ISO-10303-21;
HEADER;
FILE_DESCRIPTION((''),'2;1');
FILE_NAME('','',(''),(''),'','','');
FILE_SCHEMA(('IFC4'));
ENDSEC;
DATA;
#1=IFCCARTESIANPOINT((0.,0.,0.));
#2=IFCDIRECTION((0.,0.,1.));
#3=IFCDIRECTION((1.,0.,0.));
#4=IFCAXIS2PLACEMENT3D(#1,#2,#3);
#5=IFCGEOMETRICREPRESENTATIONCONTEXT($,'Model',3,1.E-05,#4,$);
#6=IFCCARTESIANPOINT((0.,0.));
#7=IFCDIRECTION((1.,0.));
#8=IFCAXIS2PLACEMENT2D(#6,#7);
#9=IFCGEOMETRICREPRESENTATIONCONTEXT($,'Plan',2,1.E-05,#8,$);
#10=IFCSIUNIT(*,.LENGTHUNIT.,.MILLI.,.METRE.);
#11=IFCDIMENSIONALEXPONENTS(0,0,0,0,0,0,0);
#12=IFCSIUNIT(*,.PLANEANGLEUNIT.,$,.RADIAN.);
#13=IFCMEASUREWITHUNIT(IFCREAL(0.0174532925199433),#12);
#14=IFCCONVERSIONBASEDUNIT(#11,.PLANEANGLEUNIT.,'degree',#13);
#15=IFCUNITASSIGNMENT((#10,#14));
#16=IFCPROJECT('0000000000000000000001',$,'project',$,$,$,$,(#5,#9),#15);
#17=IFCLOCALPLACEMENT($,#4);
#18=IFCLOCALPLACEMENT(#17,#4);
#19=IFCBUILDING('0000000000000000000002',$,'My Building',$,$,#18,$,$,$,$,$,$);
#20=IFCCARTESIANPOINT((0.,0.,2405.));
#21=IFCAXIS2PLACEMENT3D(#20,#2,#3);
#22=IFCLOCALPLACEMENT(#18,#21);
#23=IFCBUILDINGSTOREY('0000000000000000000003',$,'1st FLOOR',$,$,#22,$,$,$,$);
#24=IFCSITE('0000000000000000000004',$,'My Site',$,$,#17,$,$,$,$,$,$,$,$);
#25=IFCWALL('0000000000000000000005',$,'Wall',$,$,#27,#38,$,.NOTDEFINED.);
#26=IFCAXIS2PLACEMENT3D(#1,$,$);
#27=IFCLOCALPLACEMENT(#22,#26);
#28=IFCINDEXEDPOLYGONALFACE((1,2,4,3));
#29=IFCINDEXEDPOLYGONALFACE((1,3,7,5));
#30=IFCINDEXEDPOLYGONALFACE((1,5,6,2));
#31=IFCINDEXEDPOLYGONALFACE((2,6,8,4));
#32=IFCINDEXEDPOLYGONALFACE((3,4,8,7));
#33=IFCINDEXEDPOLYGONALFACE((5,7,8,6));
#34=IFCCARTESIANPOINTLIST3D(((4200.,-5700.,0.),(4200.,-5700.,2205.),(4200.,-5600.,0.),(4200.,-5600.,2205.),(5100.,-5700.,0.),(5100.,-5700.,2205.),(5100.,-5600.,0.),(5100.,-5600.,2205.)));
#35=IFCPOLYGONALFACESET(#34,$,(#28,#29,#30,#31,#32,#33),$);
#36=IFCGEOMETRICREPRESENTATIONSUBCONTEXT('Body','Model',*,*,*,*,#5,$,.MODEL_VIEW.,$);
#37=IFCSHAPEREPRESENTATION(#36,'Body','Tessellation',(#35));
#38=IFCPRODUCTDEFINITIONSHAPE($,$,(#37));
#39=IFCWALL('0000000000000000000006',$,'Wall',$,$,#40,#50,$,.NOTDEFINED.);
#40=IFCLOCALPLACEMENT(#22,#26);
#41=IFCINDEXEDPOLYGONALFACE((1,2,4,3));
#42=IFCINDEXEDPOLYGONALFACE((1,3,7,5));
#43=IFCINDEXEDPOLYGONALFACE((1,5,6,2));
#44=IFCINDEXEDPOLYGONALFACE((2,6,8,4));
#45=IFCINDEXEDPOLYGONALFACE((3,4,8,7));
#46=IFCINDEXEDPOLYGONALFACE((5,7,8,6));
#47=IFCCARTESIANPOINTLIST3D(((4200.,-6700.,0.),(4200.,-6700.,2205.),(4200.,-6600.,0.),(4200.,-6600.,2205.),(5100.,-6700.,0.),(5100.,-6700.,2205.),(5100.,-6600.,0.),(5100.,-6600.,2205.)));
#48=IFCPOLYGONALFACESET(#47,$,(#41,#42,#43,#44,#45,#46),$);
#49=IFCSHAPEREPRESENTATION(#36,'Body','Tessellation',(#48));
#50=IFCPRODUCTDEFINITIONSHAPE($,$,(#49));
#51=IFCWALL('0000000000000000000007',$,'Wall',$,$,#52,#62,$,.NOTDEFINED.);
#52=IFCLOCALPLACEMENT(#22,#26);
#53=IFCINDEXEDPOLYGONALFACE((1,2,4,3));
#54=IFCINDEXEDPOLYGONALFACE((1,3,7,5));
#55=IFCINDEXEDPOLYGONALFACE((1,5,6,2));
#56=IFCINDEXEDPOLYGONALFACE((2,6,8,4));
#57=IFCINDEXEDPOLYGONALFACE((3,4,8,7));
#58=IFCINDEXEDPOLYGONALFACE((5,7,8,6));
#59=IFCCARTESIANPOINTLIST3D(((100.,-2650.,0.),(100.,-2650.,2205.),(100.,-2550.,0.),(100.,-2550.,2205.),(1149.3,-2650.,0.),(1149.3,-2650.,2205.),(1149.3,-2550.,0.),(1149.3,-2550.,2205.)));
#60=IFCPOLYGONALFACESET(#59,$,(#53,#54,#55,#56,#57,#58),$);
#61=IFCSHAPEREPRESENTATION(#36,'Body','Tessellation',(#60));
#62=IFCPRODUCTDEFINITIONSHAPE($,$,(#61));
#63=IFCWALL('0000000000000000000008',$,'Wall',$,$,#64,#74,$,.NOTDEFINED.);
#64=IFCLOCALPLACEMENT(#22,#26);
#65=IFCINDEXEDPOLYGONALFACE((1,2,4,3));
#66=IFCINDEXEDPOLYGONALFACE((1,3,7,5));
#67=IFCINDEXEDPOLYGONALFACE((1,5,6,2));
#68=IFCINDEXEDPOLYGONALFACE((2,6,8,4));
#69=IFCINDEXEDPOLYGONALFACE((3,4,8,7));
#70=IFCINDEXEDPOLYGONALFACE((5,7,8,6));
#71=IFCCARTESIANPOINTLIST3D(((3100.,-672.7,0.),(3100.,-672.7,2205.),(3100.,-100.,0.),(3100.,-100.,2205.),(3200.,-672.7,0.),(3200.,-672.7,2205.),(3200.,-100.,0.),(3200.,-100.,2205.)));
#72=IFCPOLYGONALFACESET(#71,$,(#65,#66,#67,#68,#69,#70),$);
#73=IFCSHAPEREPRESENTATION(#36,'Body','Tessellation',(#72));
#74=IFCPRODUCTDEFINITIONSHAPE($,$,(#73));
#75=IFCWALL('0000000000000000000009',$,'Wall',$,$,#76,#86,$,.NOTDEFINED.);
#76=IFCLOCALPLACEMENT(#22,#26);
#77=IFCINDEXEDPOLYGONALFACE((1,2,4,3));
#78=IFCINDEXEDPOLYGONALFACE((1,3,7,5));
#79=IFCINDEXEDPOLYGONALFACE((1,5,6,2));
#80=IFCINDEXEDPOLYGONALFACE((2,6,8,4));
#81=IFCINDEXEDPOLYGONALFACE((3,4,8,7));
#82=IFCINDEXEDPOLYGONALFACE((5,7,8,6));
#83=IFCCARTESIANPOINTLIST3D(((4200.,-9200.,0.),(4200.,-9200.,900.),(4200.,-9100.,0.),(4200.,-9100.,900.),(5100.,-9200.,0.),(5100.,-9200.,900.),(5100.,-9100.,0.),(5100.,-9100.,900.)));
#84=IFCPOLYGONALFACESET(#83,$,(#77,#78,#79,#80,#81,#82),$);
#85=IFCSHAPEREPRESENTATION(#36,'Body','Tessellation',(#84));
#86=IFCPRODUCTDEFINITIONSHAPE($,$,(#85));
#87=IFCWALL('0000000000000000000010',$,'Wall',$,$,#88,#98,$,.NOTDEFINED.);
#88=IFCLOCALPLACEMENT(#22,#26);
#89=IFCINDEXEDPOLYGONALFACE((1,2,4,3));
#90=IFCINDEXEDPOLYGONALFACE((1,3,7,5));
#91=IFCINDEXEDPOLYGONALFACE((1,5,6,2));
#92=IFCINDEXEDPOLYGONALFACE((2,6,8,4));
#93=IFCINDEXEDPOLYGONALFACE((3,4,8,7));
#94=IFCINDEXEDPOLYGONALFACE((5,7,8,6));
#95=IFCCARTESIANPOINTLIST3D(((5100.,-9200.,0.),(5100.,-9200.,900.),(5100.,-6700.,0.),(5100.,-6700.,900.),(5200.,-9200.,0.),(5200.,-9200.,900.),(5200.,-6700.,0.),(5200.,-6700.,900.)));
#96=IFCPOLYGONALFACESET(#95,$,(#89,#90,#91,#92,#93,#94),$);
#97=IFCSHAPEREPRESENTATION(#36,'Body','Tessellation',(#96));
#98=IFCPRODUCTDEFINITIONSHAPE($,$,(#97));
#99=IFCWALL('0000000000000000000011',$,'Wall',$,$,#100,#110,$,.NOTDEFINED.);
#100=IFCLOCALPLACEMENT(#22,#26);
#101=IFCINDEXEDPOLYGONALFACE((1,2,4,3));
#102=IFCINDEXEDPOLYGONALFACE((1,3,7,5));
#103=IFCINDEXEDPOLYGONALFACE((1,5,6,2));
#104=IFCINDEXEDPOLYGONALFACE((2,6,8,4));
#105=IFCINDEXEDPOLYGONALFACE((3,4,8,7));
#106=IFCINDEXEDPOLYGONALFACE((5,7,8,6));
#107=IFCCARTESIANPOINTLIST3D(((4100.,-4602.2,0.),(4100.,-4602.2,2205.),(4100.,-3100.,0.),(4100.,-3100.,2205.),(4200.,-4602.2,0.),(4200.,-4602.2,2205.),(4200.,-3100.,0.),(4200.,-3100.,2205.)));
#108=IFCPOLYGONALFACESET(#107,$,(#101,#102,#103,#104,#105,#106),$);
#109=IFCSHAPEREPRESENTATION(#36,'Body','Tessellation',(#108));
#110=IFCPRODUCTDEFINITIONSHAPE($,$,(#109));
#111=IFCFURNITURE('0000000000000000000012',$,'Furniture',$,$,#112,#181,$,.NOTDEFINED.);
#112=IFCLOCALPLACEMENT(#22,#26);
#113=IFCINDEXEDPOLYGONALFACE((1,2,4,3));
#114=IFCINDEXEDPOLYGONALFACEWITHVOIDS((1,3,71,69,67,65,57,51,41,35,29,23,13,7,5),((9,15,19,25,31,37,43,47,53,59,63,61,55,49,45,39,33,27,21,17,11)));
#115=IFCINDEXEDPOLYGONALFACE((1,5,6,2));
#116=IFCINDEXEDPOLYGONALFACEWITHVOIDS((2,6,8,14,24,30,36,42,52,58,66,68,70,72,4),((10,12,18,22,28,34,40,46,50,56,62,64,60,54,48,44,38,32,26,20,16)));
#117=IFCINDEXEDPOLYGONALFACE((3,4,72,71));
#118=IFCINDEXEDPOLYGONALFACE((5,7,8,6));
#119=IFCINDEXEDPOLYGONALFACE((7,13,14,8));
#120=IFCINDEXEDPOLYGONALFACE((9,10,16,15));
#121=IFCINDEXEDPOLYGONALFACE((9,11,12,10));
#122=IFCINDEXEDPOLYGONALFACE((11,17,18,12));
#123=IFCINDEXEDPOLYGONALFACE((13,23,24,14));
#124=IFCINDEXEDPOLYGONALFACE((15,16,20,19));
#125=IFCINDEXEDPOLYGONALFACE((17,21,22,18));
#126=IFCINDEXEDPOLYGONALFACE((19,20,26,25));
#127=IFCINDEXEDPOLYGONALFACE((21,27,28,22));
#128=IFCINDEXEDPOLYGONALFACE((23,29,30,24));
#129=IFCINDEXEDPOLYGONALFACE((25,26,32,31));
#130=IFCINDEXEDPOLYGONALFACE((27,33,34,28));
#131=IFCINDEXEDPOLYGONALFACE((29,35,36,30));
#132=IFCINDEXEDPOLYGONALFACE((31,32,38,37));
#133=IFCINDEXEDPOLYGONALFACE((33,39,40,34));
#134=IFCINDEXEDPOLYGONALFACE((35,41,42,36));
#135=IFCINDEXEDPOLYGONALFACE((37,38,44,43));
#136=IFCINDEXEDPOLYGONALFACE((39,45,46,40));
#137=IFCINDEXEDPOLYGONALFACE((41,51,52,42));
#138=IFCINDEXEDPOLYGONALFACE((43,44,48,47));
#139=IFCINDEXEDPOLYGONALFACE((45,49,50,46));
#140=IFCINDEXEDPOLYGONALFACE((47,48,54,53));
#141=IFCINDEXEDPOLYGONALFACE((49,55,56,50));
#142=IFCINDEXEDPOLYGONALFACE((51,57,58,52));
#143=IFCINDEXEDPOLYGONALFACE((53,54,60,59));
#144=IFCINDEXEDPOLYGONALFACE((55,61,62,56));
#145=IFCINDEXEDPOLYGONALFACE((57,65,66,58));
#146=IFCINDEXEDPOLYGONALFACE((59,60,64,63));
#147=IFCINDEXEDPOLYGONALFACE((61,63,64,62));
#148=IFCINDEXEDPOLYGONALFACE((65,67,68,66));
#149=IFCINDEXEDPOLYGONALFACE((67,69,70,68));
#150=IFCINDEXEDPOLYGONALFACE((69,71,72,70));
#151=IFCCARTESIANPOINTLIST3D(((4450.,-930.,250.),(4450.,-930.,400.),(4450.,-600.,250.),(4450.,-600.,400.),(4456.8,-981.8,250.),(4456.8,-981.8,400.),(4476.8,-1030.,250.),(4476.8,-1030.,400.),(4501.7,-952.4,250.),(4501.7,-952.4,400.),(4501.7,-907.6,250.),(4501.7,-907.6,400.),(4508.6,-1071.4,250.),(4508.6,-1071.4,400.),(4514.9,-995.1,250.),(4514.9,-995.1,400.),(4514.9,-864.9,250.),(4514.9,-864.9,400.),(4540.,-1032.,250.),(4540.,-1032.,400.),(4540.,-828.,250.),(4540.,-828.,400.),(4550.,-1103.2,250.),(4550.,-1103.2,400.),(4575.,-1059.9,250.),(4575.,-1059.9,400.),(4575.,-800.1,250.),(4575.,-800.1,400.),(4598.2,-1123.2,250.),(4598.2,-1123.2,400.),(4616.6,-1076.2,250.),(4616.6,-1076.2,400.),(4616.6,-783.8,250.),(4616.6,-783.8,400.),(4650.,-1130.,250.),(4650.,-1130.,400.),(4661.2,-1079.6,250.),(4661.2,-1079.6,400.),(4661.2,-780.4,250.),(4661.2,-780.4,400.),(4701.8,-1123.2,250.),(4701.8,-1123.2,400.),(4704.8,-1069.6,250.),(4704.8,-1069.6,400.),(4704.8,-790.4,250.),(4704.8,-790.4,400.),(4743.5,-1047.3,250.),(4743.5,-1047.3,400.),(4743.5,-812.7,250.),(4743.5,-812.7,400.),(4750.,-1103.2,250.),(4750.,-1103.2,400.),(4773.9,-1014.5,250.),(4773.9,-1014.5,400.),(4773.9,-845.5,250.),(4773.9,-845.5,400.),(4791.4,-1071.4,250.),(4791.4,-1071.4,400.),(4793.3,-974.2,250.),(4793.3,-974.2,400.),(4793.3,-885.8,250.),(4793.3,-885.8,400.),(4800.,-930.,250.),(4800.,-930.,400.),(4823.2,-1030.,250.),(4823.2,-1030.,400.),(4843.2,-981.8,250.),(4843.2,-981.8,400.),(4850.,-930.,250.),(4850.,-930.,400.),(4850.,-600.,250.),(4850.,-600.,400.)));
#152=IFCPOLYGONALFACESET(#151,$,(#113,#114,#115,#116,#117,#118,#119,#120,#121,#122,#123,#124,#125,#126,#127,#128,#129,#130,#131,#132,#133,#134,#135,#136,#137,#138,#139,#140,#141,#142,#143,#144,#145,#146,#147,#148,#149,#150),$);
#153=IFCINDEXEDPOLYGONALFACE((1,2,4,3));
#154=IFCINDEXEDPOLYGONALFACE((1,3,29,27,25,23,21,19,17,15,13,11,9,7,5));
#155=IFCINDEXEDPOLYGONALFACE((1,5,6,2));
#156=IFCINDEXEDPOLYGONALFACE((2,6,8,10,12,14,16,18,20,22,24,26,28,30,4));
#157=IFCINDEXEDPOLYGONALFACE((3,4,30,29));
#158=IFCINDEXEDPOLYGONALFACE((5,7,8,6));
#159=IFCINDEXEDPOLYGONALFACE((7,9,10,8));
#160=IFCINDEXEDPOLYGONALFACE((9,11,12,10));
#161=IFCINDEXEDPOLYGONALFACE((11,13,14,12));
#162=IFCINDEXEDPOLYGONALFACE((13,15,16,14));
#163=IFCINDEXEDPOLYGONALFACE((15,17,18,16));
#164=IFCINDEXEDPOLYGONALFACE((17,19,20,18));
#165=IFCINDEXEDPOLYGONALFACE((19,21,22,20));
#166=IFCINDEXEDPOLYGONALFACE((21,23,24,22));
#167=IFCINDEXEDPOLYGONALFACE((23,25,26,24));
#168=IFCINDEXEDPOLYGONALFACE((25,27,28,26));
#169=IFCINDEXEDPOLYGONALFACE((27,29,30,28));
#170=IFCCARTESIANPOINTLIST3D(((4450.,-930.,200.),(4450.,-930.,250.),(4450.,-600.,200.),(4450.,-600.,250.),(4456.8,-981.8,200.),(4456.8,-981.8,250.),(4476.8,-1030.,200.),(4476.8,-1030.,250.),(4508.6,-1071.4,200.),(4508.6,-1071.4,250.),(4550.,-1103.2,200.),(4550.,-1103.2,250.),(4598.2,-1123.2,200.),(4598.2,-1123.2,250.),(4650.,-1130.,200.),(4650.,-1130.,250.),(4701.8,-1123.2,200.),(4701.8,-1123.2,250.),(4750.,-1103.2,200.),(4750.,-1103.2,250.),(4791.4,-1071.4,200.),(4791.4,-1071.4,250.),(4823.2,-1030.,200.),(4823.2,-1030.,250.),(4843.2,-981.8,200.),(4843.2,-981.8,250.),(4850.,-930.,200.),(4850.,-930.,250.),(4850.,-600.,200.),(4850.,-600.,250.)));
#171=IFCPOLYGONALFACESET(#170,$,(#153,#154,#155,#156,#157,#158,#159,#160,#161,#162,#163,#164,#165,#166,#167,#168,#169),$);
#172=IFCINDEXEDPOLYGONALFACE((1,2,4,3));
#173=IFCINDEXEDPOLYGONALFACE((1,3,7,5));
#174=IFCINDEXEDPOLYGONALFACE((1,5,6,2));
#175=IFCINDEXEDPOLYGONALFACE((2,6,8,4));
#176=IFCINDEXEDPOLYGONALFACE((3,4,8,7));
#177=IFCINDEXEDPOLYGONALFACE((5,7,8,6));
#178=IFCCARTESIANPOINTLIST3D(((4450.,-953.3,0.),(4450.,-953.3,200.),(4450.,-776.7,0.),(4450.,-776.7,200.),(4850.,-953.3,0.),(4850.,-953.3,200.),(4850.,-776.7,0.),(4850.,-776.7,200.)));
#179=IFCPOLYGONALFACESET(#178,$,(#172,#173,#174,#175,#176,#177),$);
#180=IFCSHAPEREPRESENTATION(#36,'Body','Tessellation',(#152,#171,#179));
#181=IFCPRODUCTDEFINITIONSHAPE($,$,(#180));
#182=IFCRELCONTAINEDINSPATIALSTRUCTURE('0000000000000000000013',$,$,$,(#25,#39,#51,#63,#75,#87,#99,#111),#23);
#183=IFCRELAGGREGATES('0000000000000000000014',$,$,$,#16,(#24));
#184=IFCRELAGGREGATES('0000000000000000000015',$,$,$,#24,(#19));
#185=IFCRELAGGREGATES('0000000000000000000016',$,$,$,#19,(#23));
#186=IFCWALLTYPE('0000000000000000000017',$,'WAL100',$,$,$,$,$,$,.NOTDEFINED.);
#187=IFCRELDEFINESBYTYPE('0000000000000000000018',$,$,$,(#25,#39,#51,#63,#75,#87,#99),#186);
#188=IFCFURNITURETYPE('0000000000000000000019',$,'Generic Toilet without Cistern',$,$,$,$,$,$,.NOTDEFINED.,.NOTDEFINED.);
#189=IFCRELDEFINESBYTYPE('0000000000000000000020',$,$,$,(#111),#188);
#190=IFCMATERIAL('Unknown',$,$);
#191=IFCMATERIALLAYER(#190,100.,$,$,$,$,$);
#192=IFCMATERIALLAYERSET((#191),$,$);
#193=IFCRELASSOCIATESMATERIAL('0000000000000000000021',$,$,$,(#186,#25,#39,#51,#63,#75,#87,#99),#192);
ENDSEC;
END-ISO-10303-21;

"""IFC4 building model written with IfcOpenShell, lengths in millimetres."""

from ifc_helpers import new_model, entity, si_unit, converted_unit, frame, frame_2d, origin_with_axes, origin_2d_with_axis, place, context, subcontext, project, spatial, line, arc, indexed_curve, circle_curve, outline, extrude, source, transform, mapped, material, layer, layer_set, layer_usage, type_object, type_shapes, element, save


model = new_model("IFC4")

# Units and contexts
model_context = context("Model", 3, precision=1e-05, world=origin_with_axes())
plan_context = context("Plan", 2, precision=1e-05, world=origin_2d_with_axis())
body_context = subcontext(model_context, "Body", "Model", "MODEL_VIEW")
ifc_project = project(units=[si_unit("LENGTHUNIT", "METRE", prefix="MILLI"), converted_unit("PLANEANGLEUNIT", "degree", entity("IfcReal", 0.0174532925199433), si_unit("PLANEANGLEUNIT", "RADIAN"), dimensions=[0, 0, 0, 0, 0, 0, 0])], contexts=[model_context, plan_context])

# Site, building, storey
site_placement = place(None, origin_with_axes())
site = spatial("IfcSite", under=ifc_project, at=site_placement, Name="My Site")
building_placement = place(site_placement, origin_with_axes())
building = spatial("IfcBuilding", under=site, at=building_placement, Name="My Building")
storey_placement = place(building_placement, frame((0.0, 0.0, 2405.0), z_axis=(0.0, 0.0, 1.0), x_axis=(1.0, 0.0, 0.0)))
storey = spatial("IfcBuildingStorey", under=building, at=storey_placement, Name="1st FLOOR")

# Shared definitions
ifc_material = material(Name="Unknown")

# Walls
ifc_layer_1 = layer(ifc_material, 100.0)
ifc_layer_set_1 = layer_set([ifc_layer_1])
wall_type = type_object("IfcWallType", Name="WAL100", PredefinedType="NOTDEFINED", material=ifc_layer_set_1)
ifc_layer_usage_1 = layer_usage(ifc_layer_set_1, "AXIS2", "POSITIVE", 0.0)
wall_1_placement = place(storey_placement, frame((5100.0, -5600.0, 0.0), z_axis=(0.0, 0.0, 1.0), x_axis=(-1.0, 0.0, 0.0)))
element("IfcWall", 1, at=wall_1_placement, inside=storey, type_object=wall_type, material=ifc_layer_usage_1, Name="Wall", PredefinedType="NOTDEFINED", context=body_context, shape_type="SweptSolid", body=[
    extrude(outline(indexed_curve([(0.0, 0.0), (0.0, 100.0), (900.0, 100.0), (900.0, 0.0), (0.0, 0.0)], self_intersect=False)), origin_with_axes(), (0.0, 0.0, 1.0), 2205.0),
])
ifc_layer_usage_2 = layer_usage(ifc_layer_set_1, "AXIS2", "POSITIVE", 0.0)
wall_2_placement = place(storey_placement, frame((5100.0, -6600.0, 0.0), z_axis=(0.0, 0.0, 1.0), x_axis=(-1.0, 0.0, 0.0)))
element("IfcWall", 2, at=wall_2_placement, inside=storey, type_object=wall_type, material=ifc_layer_usage_2, Name="Wall", PredefinedType="NOTDEFINED", context=body_context, shape_type="SweptSolid", body=[
    extrude(outline(indexed_curve([(0.0, 0.0), (0.0, 100.0), (900.0, 100.0), (900.0, 0.0), (0.0, 0.0)], self_intersect=False)), origin_with_axes(), (0.0, 0.0, 1.0), 2205.0),
])
ifc_layer_usage_3 = layer_usage(ifc_layer_set_1, "AXIS2", "POSITIVE", 0.0)
wall_3_placement = place(storey_placement, frame((1149.3, -2550.0, 0.0), z_axis=(0.0, 0.0, 1.0), x_axis=(-1.0, 0.000001, 0.0)))
element("IfcWall", 3, at=wall_3_placement, inside=storey, type_object=wall_type, material=ifc_layer_usage_3, Name="Wall", PredefinedType="NOTDEFINED", context=body_context, shape_type="SweptSolid", body=[
    extrude(outline(indexed_curve([(0.0, 0.0), (0.0, 100.0), (1049.3, 100.0), (1049.3, 0.0), (0.0, 0.0)], self_intersect=False)), origin_with_axes(), (0.0, 0.0, 1.0), 2205.0),
])
ifc_layer_usage_4 = layer_usage(ifc_layer_set_1, "AXIS2", "POSITIVE", 0.0)
wall_4_placement = place(storey_placement, frame((3200.0, -672.7, 0.0), z_axis=(0.0, 0.0, 1.0), x_axis=(0.000001, 1.0, 0.0)))
element("IfcWall", 4, at=wall_4_placement, inside=storey, type_object=wall_type, material=ifc_layer_usage_4, Name="Wall", PredefinedType="NOTDEFINED", context=body_context, shape_type="SweptSolid", body=[
    extrude(outline(indexed_curve([(0.0, 0.0), (0.0, 100.0), (572.7, 100.0), (572.7, 0.0), (0.0, 0.0)], self_intersect=False)), origin_with_axes(), (0.0, 0.0, 1.0), 2205.0),
])
ifc_layer_usage_5 = layer_usage(ifc_layer_set_1, "AXIS2", "POSITIVE", 0.0)
wall_5_placement = place(storey_placement, frame((4200.0, -9200.0, 0.0), z_axis=(0.0, 0.0, 1.0), x_axis=(1.0, -0.000001, 0.0)))
element("IfcWall", 5, at=wall_5_placement, inside=storey, type_object=wall_type, material=ifc_layer_usage_5, Name="Wall", PredefinedType="NOTDEFINED", context=body_context, shape_type="SweptSolid", body=[
    extrude(outline(indexed_curve([(0.0, 0.0), (0.0, 100.0), (900.0, 100.0), (900.0, 0.0), (0.0, 0.0)], self_intersect=False)), origin_with_axes(), (0.0, 0.0, 1.0), 900.0),
])
ifc_layer_usage_6 = layer_usage(ifc_layer_set_1, "AXIS2", "POSITIVE", 0.0)
wall_6_placement = place(storey_placement, frame((5100.0, -6700.0, 0.0), z_axis=(0.0, 0.0, 1.0), x_axis=(-0.000001, -1.0, 0.0)))
element("IfcWall", 6, at=wall_6_placement, inside=storey, type_object=wall_type, material=ifc_layer_usage_6, Name="Wall", PredefinedType="NOTDEFINED", context=body_context, shape_type="SweptSolid", body=[
    extrude(outline(indexed_curve([(0.0, 0.0), (0.0, 100.0), (2500.0, 100.0), (2500.0, 0.0), (0.0, 0.0)], self_intersect=False)), origin_with_axes(), (0.0, 0.0, 1.0), 900.0),
])
ifc_layer_usage_7 = layer_usage(ifc_layer_set_1, "AXIS2", "POSITIVE", 0.0)
wall_7_placement = place(storey_placement, frame((4200.0, -4602.2, 0.0), z_axis=(0.0, 0.0, 1.0), x_axis=(0.000001, 1.0, 0.0)))
element("IfcWall", 7, at=wall_7_placement, inside=storey, type_object=wall_type, material=ifc_layer_usage_7, Name="Wall", PredefinedType="NOTDEFINED", context=body_context, shape_type="SweptSolid", body=[
    extrude(outline(indexed_curve([(0.0, 0.0), (0.0, 100.0), (1502.2, 100.0), (1502.2, 0.0), (0.0, 0.0)], self_intersect=False)), origin_with_axes(), (0.0, 0.0, 1.0), 2205.0),
])

# Furniture
furniture_type_1 = type_object("IfcFurnitureType", Name="Generic Toilet without Cistern", AssemblyPlace="NOTDEFINED", PredefinedType="NOTDEFINED")
shared_shape_1 = source(origin_with_axes(), body_context, "Body", "SweptSolid", [
    extrude(outline(indexed_curve([(-200.0, 0.0, 0.0), (-200.0, -330.0, 0.0), (-141.4, -471.4, 0.0), (0.0, -530.0, 0.0), (141.4, -471.4, 0.0), (200.0, -330.0, 0.0), (200.0, 0.0, 0.0)], segments=[line(1, 2), arc(2, 3, 4), arc(4, 5, 6), line(6, 7), line(1, 7)]), holes=[circle_curve(frame_2d((0.0, -330.0)), 150.0)]), frame((0.0, 0.0, 250.0), z_axis=(0.0, 0.0, 1.0), x_axis=(1.0, 0.0, 0.0)), (0.0, 0.0, 1.0), 150.0),
    extrude(outline(indexed_curve([(-200.0, 0.0, 0.0), (-200.0, -330.0, 0.0), (-141.4, -471.4, 0.0), (0.0, -530.0, 0.0), (141.4, -471.4, 0.0), (200.0, -330.0, 0.0), (200.0, 0.0, 0.0)], segments=[line(1, 2), arc(2, 3, 4), arc(4, 5, 6), line(6, 7), line(1, 7)])), frame((0.0, 0.0, 200.0), z_axis=(0.0, 0.0, 1.0), x_axis=(1.0, 0.0, 0.0)), (0.0, 0.0, 1.0), 50.0),
    extrude(outline(indexed_curve([(-200.0, -176.7, 0.0), (-200.0, -353.3, 0.0), (200.0, -353.3, 0.0), (200.0, -176.7, 0.0)], segments=[line(1, 2), line(2, 3), line(3, 4), line(4, 1)])), origin_with_axes(), (0.0, 0.0, 1.0), 200.0),
])
type_shapes(furniture_type_1, [shared_shape_1])
furniture_1_placement = place(storey_placement, frame((4650.0, -600.0, 0.0), z_axis=(0.0, 0.0, 1.0), x_axis=(1.0, 0.0, 0.0)))
element("IfcFurniture", 8, at=furniture_1_placement, inside=storey, type_object=furniture_type_1, Name="Furniture", PredefinedType="NOTDEFINED", context=body_context, shape_type="MappedRepresentation", body=[
    mapped(shared_shape_1, transform((0.0, 0.0, 0.0), x_axis=(1.0, 0.0, 0.0), y_axis=(0.0, 1.0, 0.0), z_axis=(0.0, 0.0, 1.0), scale=1.0)),
])

save(model, "model.ifc")
